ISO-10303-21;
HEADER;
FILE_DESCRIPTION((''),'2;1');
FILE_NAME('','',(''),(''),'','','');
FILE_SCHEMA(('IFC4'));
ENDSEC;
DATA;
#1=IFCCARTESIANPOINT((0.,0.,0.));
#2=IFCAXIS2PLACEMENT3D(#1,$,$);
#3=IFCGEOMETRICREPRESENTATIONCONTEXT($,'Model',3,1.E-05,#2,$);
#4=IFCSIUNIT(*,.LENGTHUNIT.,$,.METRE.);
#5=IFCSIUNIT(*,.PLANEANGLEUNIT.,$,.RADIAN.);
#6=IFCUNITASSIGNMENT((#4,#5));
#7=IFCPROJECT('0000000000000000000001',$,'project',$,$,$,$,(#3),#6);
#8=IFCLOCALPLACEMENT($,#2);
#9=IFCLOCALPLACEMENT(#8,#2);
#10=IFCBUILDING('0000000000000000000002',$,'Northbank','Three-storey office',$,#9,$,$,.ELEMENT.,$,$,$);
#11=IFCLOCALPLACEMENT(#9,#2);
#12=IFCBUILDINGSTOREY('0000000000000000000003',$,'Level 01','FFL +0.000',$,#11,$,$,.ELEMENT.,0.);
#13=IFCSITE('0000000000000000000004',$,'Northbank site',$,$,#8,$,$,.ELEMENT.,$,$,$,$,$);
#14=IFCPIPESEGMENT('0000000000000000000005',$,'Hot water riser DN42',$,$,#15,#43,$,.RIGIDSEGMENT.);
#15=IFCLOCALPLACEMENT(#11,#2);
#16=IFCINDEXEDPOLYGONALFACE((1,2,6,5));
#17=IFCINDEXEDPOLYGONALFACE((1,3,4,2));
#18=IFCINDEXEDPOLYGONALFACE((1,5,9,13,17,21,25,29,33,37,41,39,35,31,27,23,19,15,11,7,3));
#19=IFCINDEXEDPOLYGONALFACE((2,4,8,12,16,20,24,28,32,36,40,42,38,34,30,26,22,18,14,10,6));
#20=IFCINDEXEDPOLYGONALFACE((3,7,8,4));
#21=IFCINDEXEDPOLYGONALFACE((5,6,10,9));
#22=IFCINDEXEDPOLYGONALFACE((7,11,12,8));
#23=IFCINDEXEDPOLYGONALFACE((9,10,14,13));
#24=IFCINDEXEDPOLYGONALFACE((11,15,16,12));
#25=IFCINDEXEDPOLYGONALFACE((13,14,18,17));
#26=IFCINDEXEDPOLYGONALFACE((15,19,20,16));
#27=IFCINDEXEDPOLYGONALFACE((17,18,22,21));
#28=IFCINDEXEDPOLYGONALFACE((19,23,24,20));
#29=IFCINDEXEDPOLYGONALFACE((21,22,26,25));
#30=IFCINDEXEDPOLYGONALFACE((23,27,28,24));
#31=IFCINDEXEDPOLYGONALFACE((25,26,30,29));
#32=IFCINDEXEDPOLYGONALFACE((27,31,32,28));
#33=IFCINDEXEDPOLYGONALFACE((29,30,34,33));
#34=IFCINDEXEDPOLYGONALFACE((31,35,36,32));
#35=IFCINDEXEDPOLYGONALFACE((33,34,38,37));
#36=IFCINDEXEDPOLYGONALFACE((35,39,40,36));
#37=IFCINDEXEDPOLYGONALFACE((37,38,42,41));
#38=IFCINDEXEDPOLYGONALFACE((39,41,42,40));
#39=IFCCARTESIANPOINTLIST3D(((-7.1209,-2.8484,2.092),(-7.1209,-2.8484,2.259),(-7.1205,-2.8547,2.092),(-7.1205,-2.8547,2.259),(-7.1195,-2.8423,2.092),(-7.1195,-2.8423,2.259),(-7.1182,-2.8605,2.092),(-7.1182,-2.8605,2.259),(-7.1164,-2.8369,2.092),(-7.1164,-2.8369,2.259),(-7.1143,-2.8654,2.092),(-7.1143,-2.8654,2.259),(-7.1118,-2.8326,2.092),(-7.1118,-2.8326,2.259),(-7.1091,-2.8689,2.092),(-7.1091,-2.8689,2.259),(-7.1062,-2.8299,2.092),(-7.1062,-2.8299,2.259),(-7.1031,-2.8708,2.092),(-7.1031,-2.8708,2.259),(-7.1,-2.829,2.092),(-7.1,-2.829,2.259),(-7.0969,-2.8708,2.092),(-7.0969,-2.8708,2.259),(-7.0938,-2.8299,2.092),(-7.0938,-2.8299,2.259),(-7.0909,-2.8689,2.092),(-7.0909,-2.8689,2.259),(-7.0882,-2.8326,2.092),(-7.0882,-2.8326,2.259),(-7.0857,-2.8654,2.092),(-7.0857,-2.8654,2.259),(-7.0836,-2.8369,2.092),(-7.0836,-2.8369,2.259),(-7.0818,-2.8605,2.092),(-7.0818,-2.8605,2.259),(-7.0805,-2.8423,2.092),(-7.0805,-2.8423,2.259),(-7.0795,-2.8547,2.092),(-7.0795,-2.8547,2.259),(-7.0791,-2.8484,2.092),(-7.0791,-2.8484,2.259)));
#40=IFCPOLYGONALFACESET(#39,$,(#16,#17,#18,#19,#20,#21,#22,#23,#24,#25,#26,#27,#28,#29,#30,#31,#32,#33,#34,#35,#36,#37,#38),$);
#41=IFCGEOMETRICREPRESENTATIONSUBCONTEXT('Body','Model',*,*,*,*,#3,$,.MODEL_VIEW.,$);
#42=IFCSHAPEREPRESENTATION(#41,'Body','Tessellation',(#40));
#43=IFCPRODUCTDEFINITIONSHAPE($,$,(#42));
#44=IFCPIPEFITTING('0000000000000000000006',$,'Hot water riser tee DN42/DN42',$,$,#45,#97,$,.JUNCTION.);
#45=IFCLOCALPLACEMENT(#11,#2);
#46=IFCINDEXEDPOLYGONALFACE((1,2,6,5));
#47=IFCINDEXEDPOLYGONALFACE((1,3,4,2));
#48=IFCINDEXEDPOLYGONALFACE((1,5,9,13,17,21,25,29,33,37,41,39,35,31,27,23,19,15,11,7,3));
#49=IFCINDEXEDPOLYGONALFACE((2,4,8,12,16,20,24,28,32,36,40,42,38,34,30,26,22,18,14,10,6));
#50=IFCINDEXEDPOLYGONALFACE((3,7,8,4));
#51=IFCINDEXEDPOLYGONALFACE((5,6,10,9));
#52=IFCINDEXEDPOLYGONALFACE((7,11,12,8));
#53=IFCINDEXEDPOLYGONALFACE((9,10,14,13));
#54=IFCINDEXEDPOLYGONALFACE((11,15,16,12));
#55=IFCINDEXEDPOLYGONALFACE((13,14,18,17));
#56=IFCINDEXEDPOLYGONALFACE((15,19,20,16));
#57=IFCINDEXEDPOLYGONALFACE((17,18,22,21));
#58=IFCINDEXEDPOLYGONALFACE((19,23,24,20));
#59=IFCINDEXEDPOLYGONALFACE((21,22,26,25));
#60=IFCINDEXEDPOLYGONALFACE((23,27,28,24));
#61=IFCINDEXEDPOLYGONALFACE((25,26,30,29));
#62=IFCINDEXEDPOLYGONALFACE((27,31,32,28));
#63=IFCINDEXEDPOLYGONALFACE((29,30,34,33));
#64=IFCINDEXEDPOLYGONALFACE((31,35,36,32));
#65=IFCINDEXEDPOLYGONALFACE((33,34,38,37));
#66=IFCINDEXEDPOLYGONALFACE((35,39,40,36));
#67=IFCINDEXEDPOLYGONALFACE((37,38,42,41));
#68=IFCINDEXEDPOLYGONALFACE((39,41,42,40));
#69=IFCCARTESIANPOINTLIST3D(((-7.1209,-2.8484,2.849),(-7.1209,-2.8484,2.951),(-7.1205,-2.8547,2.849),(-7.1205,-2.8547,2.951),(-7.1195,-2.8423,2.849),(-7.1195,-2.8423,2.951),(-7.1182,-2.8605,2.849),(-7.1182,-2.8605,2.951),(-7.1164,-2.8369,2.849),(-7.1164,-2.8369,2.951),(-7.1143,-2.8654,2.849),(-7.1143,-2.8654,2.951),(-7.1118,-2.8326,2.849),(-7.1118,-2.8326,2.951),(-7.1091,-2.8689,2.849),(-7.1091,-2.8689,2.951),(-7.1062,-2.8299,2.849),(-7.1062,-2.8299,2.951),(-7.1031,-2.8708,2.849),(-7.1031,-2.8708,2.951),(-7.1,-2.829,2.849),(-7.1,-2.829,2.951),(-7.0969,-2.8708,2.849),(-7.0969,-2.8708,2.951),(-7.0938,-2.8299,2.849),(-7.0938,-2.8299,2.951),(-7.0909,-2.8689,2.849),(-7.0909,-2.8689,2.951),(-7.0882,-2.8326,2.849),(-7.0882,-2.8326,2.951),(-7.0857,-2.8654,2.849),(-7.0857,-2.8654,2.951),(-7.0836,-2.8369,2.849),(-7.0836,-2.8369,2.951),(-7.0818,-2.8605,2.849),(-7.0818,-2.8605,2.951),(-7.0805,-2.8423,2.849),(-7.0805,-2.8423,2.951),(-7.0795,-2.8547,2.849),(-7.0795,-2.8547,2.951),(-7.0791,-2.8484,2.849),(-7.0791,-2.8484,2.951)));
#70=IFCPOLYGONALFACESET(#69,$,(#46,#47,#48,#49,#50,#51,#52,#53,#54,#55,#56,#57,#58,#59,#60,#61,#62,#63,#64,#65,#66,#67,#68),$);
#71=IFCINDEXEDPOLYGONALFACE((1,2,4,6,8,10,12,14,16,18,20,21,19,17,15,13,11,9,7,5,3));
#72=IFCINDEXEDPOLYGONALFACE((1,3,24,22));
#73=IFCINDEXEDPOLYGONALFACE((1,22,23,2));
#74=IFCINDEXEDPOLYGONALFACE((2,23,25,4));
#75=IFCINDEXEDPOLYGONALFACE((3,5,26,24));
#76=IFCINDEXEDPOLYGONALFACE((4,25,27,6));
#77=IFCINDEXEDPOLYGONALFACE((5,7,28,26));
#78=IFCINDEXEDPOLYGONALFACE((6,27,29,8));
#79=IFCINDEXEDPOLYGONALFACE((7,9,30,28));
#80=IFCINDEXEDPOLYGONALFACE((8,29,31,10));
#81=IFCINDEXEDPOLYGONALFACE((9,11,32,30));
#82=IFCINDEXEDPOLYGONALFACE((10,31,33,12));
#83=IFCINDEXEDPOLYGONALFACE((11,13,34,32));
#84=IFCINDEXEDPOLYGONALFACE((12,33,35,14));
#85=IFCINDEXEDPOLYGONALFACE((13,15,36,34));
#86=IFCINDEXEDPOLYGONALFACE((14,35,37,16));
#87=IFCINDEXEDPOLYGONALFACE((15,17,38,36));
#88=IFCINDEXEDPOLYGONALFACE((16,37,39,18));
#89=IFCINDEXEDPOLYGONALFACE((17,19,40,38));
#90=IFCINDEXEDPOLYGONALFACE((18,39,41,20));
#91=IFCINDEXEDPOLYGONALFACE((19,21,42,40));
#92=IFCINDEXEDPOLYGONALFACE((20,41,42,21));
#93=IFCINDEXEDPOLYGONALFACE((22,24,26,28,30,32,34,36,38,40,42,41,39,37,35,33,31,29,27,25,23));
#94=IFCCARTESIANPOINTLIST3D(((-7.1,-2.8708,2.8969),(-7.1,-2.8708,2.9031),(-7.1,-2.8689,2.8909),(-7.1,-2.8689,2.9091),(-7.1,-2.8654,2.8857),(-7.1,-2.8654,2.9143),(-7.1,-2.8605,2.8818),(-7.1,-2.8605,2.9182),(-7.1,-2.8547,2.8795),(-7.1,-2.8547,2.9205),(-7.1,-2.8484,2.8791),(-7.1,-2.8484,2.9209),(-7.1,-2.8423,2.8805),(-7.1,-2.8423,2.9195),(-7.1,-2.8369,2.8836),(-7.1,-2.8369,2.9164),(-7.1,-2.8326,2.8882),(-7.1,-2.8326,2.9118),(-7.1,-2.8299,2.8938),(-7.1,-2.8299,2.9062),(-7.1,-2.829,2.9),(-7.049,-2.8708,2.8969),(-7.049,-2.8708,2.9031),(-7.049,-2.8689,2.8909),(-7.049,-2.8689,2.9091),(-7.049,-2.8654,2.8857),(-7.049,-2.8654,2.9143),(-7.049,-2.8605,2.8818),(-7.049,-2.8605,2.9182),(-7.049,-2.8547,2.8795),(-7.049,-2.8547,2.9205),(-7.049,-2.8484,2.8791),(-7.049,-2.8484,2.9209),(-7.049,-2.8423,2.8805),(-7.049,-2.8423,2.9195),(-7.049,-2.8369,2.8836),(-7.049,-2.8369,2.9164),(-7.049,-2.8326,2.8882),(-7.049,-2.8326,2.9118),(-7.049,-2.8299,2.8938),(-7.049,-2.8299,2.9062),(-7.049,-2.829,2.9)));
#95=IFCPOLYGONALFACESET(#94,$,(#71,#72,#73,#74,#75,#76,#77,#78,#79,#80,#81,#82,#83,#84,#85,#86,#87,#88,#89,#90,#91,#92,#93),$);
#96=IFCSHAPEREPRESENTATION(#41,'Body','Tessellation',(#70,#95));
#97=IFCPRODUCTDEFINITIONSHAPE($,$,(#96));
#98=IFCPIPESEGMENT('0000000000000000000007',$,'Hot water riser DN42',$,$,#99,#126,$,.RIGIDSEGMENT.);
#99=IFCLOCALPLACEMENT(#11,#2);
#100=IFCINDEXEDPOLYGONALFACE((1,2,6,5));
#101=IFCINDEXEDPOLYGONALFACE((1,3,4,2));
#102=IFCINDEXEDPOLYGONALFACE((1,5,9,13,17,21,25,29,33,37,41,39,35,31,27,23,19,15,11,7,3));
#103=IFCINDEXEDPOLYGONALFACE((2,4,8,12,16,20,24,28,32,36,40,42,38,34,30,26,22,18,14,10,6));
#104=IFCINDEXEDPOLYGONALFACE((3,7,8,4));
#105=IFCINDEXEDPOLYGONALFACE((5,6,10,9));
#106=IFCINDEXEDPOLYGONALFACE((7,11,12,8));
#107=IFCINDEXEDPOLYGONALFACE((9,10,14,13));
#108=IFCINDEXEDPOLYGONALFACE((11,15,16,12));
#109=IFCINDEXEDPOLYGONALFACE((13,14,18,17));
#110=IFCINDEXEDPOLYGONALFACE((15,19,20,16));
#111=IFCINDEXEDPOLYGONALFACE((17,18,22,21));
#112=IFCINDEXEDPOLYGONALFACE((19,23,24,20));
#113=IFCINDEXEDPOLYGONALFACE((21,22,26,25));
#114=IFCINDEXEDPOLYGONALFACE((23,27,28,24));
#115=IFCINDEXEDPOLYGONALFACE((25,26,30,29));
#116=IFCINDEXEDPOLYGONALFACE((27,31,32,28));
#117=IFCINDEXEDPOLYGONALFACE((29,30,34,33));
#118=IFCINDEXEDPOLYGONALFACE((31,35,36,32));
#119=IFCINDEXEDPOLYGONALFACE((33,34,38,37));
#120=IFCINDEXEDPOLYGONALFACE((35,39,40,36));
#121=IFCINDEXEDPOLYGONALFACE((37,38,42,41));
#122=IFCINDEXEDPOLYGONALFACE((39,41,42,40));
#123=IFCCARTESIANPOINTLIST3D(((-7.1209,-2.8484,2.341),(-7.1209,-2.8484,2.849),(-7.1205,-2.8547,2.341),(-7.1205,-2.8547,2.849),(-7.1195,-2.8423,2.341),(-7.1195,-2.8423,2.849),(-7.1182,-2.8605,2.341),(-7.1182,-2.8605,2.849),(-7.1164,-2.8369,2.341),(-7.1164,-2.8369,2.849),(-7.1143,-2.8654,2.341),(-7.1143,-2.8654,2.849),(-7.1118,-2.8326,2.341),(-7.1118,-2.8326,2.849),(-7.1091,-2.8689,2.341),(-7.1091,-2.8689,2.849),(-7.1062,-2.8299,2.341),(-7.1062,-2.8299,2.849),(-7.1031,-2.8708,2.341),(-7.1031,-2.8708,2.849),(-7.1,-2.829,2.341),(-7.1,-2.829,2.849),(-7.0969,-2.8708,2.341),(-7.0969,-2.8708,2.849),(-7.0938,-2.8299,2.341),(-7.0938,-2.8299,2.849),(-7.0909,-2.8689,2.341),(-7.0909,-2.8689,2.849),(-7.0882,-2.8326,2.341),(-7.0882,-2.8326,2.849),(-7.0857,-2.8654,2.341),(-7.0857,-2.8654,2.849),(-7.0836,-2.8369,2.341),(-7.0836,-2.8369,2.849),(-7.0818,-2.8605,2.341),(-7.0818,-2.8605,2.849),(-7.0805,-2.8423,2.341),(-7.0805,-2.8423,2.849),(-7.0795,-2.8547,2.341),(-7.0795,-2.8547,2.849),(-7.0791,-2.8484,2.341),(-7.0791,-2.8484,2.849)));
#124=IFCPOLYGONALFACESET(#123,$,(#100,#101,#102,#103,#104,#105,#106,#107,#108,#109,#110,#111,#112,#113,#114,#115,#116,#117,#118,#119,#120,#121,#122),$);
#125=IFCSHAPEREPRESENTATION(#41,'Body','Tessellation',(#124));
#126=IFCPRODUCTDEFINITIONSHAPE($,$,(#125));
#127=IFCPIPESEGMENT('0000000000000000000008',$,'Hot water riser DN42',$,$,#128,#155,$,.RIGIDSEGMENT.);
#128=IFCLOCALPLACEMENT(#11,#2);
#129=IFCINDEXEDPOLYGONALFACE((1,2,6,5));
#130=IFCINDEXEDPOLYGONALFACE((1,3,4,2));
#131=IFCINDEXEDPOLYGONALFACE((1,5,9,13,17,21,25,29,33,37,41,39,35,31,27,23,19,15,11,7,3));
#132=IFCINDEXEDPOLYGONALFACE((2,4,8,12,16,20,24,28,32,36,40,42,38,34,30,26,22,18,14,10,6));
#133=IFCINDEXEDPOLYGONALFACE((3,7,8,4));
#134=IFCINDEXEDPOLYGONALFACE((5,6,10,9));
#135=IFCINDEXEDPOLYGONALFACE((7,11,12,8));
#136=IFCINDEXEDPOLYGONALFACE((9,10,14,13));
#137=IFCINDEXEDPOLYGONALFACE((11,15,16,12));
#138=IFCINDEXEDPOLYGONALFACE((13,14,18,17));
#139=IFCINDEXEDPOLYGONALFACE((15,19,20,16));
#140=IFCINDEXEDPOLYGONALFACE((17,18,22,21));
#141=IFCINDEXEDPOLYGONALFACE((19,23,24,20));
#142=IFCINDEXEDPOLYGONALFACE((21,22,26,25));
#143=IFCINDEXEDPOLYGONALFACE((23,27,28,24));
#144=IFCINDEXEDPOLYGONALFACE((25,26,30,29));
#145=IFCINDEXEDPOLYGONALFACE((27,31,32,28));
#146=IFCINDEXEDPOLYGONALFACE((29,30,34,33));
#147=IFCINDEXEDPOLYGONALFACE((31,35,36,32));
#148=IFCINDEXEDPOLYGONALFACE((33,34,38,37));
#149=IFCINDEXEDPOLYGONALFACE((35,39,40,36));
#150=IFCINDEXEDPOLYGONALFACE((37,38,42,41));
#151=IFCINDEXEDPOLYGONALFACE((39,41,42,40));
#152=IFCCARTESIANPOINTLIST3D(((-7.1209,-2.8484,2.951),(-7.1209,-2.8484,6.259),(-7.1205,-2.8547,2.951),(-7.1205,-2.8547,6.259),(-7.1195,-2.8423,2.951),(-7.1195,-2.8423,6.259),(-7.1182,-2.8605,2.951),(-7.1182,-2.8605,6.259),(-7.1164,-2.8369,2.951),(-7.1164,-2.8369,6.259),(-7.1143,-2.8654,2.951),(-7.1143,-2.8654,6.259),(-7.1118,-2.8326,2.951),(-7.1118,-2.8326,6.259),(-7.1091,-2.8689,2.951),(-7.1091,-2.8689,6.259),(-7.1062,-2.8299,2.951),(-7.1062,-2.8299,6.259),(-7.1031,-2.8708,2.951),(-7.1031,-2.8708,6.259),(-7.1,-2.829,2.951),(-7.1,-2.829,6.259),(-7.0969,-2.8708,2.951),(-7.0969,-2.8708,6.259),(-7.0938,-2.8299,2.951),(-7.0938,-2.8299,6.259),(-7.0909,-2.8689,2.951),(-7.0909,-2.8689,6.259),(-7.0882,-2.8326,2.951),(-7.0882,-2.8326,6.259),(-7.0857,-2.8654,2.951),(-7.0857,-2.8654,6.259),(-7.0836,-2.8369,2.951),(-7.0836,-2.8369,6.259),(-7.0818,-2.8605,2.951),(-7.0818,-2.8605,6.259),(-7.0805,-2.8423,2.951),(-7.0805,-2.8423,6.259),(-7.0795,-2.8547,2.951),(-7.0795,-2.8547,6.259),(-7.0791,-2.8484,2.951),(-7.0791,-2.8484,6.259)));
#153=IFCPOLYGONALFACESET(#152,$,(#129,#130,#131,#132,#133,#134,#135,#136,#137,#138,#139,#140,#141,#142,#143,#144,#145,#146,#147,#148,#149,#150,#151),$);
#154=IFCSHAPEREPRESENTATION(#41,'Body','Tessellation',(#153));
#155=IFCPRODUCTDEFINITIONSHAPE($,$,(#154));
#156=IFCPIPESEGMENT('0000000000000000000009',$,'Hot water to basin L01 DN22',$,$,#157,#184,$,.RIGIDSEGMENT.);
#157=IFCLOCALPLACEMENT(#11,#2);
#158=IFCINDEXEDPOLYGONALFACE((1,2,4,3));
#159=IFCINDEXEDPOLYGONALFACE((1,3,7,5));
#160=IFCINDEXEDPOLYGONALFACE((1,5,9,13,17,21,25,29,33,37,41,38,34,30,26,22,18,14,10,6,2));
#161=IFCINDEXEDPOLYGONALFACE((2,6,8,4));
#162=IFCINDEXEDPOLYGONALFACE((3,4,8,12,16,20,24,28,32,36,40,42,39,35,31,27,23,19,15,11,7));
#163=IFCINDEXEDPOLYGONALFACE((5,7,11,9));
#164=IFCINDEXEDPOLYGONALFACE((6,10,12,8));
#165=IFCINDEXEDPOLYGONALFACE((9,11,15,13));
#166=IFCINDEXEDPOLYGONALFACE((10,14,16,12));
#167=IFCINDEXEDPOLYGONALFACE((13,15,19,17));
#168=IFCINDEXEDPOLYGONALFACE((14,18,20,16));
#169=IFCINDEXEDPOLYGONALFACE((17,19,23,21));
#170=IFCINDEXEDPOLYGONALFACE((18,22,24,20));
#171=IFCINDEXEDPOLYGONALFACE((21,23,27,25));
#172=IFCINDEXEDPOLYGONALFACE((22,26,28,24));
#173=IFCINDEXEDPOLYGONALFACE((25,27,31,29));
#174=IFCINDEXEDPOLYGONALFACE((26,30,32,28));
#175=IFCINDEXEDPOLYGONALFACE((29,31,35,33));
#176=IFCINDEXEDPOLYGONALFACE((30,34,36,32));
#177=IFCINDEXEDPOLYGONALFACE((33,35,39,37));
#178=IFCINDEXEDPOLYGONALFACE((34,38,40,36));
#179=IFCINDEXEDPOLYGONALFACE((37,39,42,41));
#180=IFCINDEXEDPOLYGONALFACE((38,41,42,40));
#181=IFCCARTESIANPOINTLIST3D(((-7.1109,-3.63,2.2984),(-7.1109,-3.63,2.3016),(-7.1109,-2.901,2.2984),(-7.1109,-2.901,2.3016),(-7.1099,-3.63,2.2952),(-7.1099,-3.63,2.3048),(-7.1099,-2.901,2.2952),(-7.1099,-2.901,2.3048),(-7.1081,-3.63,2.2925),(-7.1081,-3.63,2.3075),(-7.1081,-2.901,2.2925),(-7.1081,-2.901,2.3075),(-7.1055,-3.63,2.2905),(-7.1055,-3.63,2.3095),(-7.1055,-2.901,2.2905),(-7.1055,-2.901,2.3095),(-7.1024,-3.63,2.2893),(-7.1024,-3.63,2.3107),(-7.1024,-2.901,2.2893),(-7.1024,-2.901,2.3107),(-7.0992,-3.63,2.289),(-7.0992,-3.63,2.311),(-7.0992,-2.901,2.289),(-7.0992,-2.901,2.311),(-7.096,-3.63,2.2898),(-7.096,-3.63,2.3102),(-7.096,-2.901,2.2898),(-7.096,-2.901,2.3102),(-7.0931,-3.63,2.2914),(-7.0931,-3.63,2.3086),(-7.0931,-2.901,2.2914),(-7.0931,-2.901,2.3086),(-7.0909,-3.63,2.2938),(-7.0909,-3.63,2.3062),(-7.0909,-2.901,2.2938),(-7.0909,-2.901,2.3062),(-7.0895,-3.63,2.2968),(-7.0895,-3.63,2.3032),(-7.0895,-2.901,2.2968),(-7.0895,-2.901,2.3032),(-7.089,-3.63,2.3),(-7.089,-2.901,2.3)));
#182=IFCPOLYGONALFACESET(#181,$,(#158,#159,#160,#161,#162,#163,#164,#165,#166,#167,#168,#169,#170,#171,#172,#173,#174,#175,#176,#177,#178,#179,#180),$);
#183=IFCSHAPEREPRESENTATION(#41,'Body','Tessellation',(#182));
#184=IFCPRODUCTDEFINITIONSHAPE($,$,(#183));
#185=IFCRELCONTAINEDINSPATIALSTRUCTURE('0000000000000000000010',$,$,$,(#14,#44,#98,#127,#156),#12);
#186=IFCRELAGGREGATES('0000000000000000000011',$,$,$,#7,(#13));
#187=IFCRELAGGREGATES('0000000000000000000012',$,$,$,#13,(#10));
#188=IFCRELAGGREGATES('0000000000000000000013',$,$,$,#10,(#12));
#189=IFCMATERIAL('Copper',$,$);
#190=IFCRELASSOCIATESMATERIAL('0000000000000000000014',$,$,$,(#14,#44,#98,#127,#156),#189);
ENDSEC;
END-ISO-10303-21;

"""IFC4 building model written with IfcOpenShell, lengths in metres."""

from ifc_helpers import new_model, si_unit, frame, origin, place, context, subcontext, project, spatial, circle, extrude, material, element, save


model = new_model("IFC4")

# Units and contexts
model_context = context("Model", 3, precision=1e-05, world=origin())
body_context = subcontext(model_context, "Body", "Model", "MODEL_VIEW")
ifc_project = project(units=[si_unit("LENGTHUNIT", "METRE"), si_unit("PLANEANGLEUNIT", "RADIAN")], contexts=[model_context])

# Site, building, storey
site_placement = place(None, origin())
site = spatial("IfcSite", under=ifc_project, at=site_placement, Name="Northbank site", CompositionType="ELEMENT")
building_placement = place(site_placement, origin())
building = spatial("IfcBuilding", under=site, at=building_placement, Name="Northbank", Description="Three-storey office", CompositionType="ELEMENT")
storey_placement = place(building_placement, origin())
storey = spatial("IfcBuildingStorey", under=building, at=storey_placement, Name="Level 01", Description="FFL +0.000", CompositionType="ELEMENT", Elevation=0.0)

# Shared definitions
ifc_material = material(Name="Copper")

# Pipe segment
pipe_segment_1_placement = place(storey_placement, origin())
element("IfcPipeSegment", 1, at=pipe_segment_1_placement, inside=storey, material=ifc_material, Name="Hot water riser DN42", PredefinedType="RIGIDSEGMENT", context=body_context, shape_type="SweptSolid", body=[
    extrude(circle(Radius=0.021), frame((-7.1, -2.85, 2.092), z_axis=(0.0, 0.0, 1.0), x_axis=(0.0, 1.0, 0.0)), (0.0, 0.0, 1.0), 0.167),
])

# Pipe fitting
pipe_fitting_1_placement = place(storey_placement, origin())
element("IfcPipeFitting", 2, at=pipe_fitting_1_placement, inside=storey, material=ifc_material, Name="Hot water riser tee DN42/DN42", PredefinedType="JUNCTION", context=body_context, shape_type="SweptSolid", body=[
    extrude(circle(Radius=0.021), frame((-7.1, -2.85, 2.849), z_axis=(0.0, 0.0, 1.0), x_axis=(0.0, 1.0, 0.0)), (0.0, 0.0, 1.0), 0.102),
    extrude(circle(Radius=0.021), frame((-7.1, -2.85, 2.9), z_axis=(1.0, 0.0, 0.0), x_axis=(0.0, 1.0, 0.0)), (0.0, 0.0, 1.0), 0.051),
])

# Pipe segments
pipe_segment_2_placement = place(storey_placement, origin())
element("IfcPipeSegment", 3, at=pipe_segment_2_placement, inside=storey, material=ifc_material, Name="Hot water riser DN42", PredefinedType="RIGIDSEGMENT", context=body_context, shape_type="SweptSolid", body=[
    extrude(circle(Radius=0.021), frame((-7.1, -2.85, 2.341), z_axis=(0.0, 0.0, 1.0), x_axis=(0.0, 1.0, 0.0)), (0.0, 0.0, 1.0), 0.508),
])
pipe_segment_3_placement = place(storey_placement, origin())
element("IfcPipeSegment", 4, at=pipe_segment_3_placement, inside=storey, material=ifc_material, Name="Hot water riser DN42", PredefinedType="RIGIDSEGMENT", context=body_context, shape_type="SweptSolid", body=[
    extrude(circle(Radius=0.021), frame((-7.1, -2.85, 2.951), z_axis=(0.0, 0.0, 1.0), x_axis=(0.0, 1.0, 0.0)), (0.0, 0.0, 1.0), 3.308),
])
pipe_segment_4_placement = place(storey_placement, origin())
element("IfcPipeSegment", 5, at=pipe_segment_4_placement, inside=storey, material=ifc_material, Name="Hot water to basin L01 DN22", PredefinedType="RIGIDSEGMENT", context=body_context, shape_type="SweptSolid", body=[
    extrude(circle(Radius=0.011), frame((-7.1, -2.901, 2.3), z_axis=(0.0, -1.0, 0.0), x_axis=(1.0, 0.0, 0.0)), (0.0, 0.0, 1.0), 0.729),
])

save(model, "model.ifc")
